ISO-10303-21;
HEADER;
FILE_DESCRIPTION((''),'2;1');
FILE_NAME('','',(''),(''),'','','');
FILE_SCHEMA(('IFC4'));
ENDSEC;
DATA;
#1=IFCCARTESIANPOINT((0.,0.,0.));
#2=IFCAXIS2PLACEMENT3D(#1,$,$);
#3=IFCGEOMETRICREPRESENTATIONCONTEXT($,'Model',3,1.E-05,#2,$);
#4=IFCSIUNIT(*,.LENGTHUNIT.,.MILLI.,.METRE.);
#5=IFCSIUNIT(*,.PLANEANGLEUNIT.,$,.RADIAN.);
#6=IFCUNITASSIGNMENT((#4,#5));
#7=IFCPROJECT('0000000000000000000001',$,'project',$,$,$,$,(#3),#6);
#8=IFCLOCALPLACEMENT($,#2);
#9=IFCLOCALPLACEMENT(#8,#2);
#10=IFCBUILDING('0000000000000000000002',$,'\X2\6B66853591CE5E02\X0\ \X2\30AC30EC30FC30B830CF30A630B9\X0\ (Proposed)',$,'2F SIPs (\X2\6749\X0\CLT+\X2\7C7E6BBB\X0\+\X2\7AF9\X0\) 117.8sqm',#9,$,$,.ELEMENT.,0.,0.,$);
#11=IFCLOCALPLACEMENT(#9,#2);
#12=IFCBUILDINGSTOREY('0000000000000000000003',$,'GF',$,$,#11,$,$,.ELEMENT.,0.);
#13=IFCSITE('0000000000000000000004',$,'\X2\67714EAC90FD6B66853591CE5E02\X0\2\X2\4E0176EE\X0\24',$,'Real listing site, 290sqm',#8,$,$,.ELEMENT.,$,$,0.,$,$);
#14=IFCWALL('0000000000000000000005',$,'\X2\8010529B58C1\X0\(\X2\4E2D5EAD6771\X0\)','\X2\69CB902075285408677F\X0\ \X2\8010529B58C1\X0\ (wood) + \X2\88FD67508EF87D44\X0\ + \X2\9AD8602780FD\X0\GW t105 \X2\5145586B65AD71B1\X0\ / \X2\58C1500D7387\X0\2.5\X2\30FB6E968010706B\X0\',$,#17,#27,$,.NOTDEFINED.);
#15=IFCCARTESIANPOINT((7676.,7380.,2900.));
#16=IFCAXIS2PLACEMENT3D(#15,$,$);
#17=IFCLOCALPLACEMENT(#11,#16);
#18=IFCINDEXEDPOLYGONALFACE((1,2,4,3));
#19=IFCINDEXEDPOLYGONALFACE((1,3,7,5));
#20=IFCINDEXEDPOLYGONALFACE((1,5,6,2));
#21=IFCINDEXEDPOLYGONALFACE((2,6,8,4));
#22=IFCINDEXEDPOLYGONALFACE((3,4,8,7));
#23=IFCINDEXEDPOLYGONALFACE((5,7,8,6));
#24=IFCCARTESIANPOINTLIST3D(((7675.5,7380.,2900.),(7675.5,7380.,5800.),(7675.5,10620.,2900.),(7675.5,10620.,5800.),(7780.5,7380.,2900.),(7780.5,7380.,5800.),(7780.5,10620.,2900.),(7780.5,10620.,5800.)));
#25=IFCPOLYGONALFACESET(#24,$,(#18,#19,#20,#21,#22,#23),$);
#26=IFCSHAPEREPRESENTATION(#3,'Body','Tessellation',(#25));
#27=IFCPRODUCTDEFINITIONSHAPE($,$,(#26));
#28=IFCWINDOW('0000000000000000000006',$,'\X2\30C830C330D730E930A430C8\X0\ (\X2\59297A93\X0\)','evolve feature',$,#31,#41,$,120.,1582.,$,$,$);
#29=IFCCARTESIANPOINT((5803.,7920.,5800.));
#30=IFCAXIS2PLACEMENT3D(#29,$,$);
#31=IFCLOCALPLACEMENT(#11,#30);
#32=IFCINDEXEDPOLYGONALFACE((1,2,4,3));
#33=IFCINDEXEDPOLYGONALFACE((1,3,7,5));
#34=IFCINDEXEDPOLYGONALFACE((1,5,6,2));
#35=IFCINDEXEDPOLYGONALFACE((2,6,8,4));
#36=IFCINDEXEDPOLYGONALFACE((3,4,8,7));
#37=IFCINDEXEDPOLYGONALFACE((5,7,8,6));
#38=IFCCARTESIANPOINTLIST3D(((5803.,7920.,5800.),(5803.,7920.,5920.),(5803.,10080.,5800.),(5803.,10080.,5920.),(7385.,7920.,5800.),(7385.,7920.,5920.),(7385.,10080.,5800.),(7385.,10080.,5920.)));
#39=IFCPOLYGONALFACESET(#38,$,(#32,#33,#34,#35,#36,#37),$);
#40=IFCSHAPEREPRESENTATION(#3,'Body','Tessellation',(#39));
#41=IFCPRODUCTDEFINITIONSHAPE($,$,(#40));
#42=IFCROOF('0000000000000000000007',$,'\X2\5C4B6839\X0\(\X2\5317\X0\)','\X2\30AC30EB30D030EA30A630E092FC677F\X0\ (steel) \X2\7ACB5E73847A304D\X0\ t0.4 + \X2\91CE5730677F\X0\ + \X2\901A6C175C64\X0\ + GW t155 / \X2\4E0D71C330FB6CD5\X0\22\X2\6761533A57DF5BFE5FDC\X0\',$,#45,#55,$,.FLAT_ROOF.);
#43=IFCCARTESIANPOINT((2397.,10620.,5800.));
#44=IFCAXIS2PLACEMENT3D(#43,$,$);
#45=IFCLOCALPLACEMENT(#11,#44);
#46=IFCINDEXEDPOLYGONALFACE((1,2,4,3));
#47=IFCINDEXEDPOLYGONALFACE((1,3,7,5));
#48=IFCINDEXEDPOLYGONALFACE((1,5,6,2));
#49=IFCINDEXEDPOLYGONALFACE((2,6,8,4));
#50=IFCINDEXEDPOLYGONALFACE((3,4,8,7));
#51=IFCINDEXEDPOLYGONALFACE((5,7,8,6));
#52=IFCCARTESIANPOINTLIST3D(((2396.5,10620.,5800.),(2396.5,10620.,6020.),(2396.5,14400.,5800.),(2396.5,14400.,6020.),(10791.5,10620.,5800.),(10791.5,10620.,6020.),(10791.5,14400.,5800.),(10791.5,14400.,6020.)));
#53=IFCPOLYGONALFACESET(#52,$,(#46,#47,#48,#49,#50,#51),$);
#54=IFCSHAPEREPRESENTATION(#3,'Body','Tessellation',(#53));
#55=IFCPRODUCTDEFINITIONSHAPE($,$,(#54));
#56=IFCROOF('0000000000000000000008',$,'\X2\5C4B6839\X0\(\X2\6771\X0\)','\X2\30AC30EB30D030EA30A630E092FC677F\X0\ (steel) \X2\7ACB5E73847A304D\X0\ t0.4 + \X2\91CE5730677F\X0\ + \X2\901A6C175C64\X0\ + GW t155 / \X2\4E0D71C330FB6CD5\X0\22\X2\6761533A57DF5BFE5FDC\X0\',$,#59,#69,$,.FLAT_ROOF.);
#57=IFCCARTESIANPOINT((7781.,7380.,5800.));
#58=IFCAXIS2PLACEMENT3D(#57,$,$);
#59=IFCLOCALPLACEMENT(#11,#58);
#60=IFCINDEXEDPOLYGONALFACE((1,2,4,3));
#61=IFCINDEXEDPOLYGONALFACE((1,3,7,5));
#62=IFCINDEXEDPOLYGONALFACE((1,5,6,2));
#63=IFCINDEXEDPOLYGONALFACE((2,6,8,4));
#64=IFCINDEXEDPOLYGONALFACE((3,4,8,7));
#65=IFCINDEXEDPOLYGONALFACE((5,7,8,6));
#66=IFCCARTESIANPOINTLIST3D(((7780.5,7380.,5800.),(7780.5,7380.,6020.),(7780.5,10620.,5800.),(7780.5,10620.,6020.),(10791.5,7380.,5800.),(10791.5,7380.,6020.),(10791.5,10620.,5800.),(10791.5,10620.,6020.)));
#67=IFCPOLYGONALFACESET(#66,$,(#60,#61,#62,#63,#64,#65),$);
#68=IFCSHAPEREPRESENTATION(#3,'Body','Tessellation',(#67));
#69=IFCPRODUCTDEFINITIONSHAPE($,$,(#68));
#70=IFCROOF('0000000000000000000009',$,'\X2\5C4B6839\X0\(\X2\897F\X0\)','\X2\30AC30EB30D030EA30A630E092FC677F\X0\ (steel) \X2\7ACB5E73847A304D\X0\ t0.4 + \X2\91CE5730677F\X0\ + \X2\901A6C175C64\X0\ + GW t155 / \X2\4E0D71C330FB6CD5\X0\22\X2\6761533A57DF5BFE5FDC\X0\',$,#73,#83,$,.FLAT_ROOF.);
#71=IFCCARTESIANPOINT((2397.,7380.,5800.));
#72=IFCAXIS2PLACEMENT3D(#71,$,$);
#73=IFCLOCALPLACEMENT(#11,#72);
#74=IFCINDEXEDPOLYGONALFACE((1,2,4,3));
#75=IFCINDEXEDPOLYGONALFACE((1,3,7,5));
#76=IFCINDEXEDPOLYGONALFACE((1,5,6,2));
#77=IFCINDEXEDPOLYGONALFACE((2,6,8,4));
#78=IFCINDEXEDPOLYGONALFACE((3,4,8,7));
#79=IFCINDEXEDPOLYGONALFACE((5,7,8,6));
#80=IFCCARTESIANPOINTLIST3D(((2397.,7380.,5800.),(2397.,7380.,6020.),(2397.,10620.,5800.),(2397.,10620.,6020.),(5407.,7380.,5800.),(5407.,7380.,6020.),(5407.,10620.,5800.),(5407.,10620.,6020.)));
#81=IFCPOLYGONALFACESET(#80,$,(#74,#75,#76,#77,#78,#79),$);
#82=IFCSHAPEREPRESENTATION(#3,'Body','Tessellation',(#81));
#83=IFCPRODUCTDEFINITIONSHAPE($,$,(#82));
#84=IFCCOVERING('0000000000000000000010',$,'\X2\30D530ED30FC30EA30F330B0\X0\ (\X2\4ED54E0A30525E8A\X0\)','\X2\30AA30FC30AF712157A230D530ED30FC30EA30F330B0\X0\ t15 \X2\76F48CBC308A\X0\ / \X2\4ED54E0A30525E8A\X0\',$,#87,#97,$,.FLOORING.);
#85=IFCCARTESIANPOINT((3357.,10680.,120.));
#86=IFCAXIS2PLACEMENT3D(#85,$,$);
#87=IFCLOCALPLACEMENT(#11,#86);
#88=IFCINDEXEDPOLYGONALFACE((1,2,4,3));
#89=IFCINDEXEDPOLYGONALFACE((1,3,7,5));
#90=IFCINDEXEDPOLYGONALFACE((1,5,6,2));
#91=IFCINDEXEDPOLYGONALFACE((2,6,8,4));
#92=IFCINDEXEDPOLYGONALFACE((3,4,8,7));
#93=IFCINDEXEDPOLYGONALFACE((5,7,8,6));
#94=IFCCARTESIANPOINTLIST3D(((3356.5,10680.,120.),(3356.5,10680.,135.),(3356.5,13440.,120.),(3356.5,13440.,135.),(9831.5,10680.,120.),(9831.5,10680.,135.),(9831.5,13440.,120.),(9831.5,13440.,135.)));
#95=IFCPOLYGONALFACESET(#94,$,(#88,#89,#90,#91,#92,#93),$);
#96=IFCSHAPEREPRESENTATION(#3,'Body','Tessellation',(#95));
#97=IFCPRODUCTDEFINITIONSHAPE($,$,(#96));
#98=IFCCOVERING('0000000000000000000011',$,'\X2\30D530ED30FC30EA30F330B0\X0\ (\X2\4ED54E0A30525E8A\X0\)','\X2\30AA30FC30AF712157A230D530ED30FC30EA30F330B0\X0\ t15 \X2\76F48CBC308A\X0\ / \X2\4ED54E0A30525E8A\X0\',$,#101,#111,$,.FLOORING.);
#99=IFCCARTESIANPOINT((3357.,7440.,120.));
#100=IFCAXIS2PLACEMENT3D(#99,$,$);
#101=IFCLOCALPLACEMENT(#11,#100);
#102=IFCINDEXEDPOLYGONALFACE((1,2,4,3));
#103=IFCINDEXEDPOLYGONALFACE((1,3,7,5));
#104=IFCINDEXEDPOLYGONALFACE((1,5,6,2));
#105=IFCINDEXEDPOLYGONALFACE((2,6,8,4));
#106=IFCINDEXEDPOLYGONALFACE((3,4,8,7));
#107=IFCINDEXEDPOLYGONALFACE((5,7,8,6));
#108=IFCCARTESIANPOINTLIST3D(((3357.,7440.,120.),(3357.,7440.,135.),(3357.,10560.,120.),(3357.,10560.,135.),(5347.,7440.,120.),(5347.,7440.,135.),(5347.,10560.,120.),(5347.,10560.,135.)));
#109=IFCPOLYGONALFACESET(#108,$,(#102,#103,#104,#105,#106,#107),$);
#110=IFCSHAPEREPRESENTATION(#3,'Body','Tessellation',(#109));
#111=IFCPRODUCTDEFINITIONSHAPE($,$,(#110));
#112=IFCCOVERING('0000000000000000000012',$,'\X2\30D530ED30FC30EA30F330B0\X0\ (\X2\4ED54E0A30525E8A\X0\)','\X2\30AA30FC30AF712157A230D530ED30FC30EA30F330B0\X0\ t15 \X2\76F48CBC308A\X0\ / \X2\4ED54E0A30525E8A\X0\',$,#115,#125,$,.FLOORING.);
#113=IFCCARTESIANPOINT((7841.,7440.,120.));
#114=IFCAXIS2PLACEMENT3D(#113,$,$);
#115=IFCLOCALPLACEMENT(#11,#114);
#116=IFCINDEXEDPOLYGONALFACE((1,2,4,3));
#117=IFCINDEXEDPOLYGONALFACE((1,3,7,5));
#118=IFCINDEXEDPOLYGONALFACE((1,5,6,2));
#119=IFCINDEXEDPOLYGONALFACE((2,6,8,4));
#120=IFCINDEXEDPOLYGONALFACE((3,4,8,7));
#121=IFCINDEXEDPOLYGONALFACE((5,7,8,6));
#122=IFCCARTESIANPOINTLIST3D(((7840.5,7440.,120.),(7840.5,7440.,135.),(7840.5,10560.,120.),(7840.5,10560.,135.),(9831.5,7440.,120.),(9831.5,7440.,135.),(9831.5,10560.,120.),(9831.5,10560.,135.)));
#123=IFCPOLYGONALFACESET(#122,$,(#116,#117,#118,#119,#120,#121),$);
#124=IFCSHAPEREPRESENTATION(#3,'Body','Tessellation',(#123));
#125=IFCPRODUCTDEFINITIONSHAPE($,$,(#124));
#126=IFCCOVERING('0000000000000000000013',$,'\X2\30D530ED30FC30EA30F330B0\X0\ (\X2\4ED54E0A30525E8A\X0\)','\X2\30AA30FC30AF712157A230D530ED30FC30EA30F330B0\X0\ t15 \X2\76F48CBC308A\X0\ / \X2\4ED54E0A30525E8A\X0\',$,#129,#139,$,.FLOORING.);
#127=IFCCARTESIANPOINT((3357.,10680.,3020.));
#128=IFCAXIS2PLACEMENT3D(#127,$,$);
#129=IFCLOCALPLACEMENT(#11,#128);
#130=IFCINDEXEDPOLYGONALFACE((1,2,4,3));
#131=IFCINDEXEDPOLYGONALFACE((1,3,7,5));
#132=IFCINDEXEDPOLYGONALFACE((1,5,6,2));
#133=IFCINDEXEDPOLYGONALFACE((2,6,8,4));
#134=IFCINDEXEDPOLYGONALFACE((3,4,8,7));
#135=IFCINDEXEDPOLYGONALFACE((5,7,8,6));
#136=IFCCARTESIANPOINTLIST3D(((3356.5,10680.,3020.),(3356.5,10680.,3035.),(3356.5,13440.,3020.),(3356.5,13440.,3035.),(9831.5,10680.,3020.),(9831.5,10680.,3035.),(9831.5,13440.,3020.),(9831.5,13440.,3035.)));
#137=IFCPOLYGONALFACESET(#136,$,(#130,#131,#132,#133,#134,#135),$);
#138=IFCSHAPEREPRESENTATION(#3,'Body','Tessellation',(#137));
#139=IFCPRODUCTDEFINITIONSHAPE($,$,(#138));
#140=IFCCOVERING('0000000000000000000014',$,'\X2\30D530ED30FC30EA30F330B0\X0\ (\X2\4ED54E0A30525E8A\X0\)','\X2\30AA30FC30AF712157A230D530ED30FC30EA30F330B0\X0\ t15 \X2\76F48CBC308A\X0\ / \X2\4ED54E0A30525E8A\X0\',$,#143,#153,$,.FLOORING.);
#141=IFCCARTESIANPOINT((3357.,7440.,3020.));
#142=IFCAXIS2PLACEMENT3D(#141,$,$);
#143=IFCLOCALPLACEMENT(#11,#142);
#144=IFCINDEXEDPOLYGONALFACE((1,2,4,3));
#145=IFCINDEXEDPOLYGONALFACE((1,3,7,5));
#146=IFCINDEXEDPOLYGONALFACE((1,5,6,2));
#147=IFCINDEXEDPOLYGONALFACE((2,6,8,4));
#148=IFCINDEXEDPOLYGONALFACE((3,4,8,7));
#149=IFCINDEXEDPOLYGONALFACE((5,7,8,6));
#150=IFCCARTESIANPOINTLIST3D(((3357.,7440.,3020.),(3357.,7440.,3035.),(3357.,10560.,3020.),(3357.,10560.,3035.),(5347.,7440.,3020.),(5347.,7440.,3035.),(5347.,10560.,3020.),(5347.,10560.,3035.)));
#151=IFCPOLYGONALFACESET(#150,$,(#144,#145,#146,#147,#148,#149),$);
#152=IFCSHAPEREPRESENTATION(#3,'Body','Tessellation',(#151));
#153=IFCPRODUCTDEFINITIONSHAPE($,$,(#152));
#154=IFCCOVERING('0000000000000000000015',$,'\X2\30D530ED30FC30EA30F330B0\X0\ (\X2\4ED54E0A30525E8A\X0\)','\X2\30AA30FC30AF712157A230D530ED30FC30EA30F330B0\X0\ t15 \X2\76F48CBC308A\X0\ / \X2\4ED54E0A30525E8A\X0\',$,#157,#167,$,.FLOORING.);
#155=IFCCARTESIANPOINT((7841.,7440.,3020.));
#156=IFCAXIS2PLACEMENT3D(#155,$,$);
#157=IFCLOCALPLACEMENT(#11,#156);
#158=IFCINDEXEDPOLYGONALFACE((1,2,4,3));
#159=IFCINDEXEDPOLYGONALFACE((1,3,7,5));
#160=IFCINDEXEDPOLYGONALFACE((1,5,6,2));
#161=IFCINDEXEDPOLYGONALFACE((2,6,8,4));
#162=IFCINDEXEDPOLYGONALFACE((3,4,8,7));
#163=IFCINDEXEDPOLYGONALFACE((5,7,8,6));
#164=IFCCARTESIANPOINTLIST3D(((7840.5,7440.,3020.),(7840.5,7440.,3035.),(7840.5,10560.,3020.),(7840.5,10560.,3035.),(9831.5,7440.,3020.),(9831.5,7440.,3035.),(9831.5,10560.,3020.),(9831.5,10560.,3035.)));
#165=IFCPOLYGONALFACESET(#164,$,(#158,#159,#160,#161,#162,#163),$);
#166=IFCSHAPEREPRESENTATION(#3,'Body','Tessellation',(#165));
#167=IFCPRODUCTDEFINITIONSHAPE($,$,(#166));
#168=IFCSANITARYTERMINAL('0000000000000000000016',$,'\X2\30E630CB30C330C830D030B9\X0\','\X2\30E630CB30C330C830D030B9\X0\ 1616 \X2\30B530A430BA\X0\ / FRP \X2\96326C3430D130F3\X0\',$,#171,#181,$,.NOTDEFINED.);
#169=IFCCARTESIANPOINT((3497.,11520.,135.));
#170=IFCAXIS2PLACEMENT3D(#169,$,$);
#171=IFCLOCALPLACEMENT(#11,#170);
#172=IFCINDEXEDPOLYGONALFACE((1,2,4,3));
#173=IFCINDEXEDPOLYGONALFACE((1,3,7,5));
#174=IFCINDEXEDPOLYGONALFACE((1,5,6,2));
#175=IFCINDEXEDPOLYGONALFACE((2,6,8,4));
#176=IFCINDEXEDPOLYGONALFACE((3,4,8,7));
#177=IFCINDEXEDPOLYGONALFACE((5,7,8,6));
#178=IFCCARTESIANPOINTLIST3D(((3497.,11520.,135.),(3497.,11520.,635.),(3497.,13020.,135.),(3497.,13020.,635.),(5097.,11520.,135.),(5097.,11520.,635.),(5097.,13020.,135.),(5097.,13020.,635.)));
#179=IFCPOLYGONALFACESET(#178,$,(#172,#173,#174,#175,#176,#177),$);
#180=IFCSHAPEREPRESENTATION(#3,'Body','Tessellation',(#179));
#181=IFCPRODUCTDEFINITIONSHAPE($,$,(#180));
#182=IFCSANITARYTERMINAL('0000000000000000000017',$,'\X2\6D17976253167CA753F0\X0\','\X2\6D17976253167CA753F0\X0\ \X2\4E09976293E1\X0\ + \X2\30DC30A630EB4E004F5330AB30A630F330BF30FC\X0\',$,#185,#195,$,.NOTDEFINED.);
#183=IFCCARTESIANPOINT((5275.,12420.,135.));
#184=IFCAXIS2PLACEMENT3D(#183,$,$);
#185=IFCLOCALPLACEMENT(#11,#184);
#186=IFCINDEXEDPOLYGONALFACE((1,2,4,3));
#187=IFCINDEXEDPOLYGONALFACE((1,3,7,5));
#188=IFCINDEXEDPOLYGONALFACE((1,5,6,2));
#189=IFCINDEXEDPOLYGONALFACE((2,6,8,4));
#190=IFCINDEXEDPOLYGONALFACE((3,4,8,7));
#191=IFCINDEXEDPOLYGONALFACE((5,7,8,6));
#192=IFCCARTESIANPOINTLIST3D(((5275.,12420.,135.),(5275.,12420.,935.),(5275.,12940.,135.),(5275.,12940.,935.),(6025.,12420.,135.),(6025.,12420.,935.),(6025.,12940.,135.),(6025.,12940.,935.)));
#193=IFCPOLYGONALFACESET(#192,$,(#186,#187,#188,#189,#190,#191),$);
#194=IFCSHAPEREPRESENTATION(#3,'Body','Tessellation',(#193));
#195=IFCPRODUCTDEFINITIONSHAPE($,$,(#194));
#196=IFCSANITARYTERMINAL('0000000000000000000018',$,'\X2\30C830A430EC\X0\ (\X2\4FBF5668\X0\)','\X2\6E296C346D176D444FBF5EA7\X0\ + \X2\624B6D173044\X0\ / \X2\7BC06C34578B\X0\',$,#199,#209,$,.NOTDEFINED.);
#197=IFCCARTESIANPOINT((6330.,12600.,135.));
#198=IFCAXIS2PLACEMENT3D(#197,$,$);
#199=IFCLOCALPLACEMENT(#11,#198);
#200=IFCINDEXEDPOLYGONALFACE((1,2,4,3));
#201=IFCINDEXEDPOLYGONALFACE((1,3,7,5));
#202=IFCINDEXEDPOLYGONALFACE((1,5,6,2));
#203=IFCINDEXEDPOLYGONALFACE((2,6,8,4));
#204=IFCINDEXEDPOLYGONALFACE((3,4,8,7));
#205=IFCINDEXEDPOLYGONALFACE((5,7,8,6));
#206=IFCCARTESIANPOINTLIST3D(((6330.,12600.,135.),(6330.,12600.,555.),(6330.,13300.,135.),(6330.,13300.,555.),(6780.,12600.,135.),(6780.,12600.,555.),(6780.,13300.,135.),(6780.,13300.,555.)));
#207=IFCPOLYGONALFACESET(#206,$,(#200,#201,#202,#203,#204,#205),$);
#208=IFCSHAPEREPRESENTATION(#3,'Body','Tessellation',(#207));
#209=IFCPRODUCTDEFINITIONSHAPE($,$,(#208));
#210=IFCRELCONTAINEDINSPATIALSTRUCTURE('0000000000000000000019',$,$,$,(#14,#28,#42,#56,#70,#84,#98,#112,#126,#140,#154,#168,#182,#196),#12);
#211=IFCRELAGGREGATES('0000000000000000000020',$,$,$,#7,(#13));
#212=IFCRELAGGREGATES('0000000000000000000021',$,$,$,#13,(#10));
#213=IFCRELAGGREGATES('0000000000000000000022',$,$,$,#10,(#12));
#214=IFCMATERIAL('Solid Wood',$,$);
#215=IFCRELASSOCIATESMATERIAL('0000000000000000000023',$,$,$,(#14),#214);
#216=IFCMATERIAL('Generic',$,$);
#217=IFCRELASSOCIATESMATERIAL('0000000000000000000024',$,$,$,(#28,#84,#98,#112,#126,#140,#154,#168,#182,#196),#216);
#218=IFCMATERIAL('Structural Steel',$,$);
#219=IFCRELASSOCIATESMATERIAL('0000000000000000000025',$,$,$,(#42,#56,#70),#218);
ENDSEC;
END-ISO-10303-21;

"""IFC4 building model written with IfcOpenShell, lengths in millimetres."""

from ifc_helpers import new_model, si_unit, frame, frame_2d, origin, place, context, project, spatial, rectangle, extrude, material, element, save


model = new_model("IFC4")

# Units and contexts
model_context = context("Model", 3, precision=1e-05, world=origin())
ifc_project = project(units=[si_unit("LENGTHUNIT", "METRE", prefix="MILLI"), si_unit("PLANEANGLEUNIT", "RADIAN")], contexts=[model_context])

# Site, building, storey
site_placement = place(None, origin())
site = spatial("IfcSite", under=ifc_project, at=site_placement, Name="東京都武蔵野市2丁目24", ObjectType="Real listing site, 290sqm", CompositionType="ELEMENT", RefElevation=0.0)
building_placement = place(site_placement, origin())
building = spatial("IfcBuilding", under=site, at=building_placement, Name="武蔵野市 ガレージハウス (Proposed)", ObjectType="2F SIPs (杉CLT+籾殻+竹) 117.8sqm", CompositionType="ELEMENT", ElevationOfRefHeight=0.0, ElevationOfTerrain=0.0)
storey_placement = place(building_placement, origin())
storey = spatial("IfcBuildingStorey", under=building, at=storey_placement, Name="GF", CompositionType="ELEMENT", Elevation=0.0)

# Shared definitions
ifc_material_1 = material(Name="Solid Wood")

# Wall
wall_1_placement = place(storey_placement, frame((7676.0, 7380.0, 2900.0)))
element("IfcWall", 1, at=wall_1_placement, inside=storey, material=ifc_material_1, Name="耐力壁(中庭東)", Description="構造用合板 耐力壁 (wood) + 製材軸組 + 高性能GW t105 充填断熱 / 壁倍率2.5・準耐火", PredefinedType="NOTDEFINED", context=model_context, shape_type="SweptSolid", body=[
    extrude(rectangle(XDim=105.0, YDim=3240.0, at=frame_2d((52.0, 1620.0))), frame((7676.0, 7380.0, 2900.0)), (0.0, 0.0, 1.0), 2900.0),
])

# Window
ifc_material_2 = material(Name="Generic")
window_1_placement = place(storey_placement, frame((5803.0, 7920.0, 5800.0)))
element("IfcWindow", 2, at=window_1_placement, inside=storey, material=ifc_material_2, Name="トップライト (天窓)", Description="evolve feature", OverallHeight=120.0, OverallWidth=1582.0, context=model_context, shape_type="SweptSolid", body=[
    extrude(rectangle(XDim=1582.0, YDim=2160.0, at=frame_2d((791.0, 1080.0))), frame((5803.0, 7920.0, 5800.0)), (0.0, 0.0, 1.0), 120.0),
])

# Roofs
ifc_material_3 = material(Name="Structural Steel")
roof_1_placement = place(storey_placement, frame((2397.0, 10620.0, 5800.0)))
element("IfcRoof", 3, at=roof_1_placement, inside=storey, material=ifc_material_3, Name="屋根(北)", Description="ガルバリウム鋼板 (steel) 立平葺き t0.4 + 野地板 + 通気層 + GW t155 / 不燃・法22条区域対応", PredefinedType="FLAT_ROOF", context=model_context, shape_type="SweptSolid", body=[
    extrude(rectangle(XDim=8395.0, YDim=3780.0, at=frame_2d((4197.0, 1890.0))), frame((2397.0, 10620.0, 5800.0)), (0.0, 0.0, 1.0), 220.0),
])
roof_2_placement = place(storey_placement, frame((7781.0, 7380.0, 5800.0)))
element("IfcRoof", 4, at=roof_2_placement, inside=storey, material=ifc_material_3, Name="屋根(東)", Description="ガルバリウム鋼板 (steel) 立平葺き t0.4 + 野地板 + 通気層 + GW t155 / 不燃・法22条区域対応", PredefinedType="FLAT_ROOF", context=model_context, shape_type="SweptSolid", body=[
    extrude(rectangle(XDim=3011.0, YDim=3240.0, at=frame_2d((1505.0, 1620.0))), frame((7781.0, 7380.0, 5800.0)), (0.0, 0.0, 1.0), 220.0),
])
roof_3_placement = place(storey_placement, frame((2397.0, 7380.0, 5800.0)))
element("IfcRoof", 5, at=roof_3_placement, inside=storey, material=ifc_material_3, Name="屋根(西)", Description="ガルバリウム鋼板 (steel) 立平葺き t0.4 + 野地板 + 通気層 + GW t155 / 不燃・法22条区域対応", PredefinedType="FLAT_ROOF", context=model_context, shape_type="SweptSolid", body=[
    extrude(rectangle(XDim=3010.0, YDim=3240.0, at=frame_2d((1505.0, 1620.0))), frame((2397.0, 7380.0, 5800.0)), (0.0, 0.0, 1.0), 220.0),
])

# Coverings
covering_1_placement = place(storey_placement, frame((3357.0, 10680.0, 120.0)))
element("IfcCovering", 6, at=covering_1_placement, inside=storey, material=ifc_material_2, Name="フローリング (仕上げ床)", Description="オーク無垢フローリング t15 直貼り / 仕上げ床", PredefinedType="FLOORING", context=model_context, shape_type="SweptSolid", body=[
    extrude(rectangle(XDim=6475.0, YDim=2760.0, at=frame_2d((3237.0, 1380.0))), frame((3357.0, 10680.0, 120.0)), (0.0, 0.0, 1.0), 15.0),
])
covering_2_placement = place(storey_placement, frame((3357.0, 7440.0, 120.0)))
element("IfcCovering", 7, at=covering_2_placement, inside=storey, material=ifc_material_2, Name="フローリング (仕上げ床)", Description="オーク無垢フローリング t15 直貼り / 仕上げ床", PredefinedType="FLOORING", context=model_context, shape_type="SweptSolid", body=[
    extrude(rectangle(XDim=1990.0, YDim=3120.0, at=frame_2d((995.0, 1560.0))), frame((3357.0, 7440.0, 120.0)), (0.0, 0.0, 1.0), 15.0),
])
covering_3_placement = place(storey_placement, frame((7841.0, 7440.0, 120.0)))
element("IfcCovering", 8, at=covering_3_placement, inside=storey, material=ifc_material_2, Name="フローリング (仕上げ床)", Description="オーク無垢フローリング t15 直貼り / 仕上げ床", PredefinedType="FLOORING", context=model_context, shape_type="SweptSolid", body=[
    extrude(rectangle(XDim=1991.0, YDim=3120.0, at=frame_2d((995.0, 1560.0))), frame((7841.0, 7440.0, 120.0)), (0.0, 0.0, 1.0), 15.0),
])
covering_4_placement = place(storey_placement, frame((3357.0, 10680.0, 3020.0)))
element("IfcCovering", 9, at=covering_4_placement, inside=storey, material=ifc_material_2, Name="フローリング (仕上げ床)", Description="オーク無垢フローリング t15 直貼り / 仕上げ床", PredefinedType="FLOORING", context=model_context, shape_type="SweptSolid", body=[
    extrude(rectangle(XDim=6475.0, YDim=2760.0, at=frame_2d((3237.0, 1380.0))), frame((3357.0, 10680.0, 3020.0)), (0.0, 0.0, 1.0), 15.0),
])
covering_5_placement = place(storey_placement, frame((3357.0, 7440.0, 3020.0)))
element("IfcCovering", 10, at=covering_5_placement, inside=storey, material=ifc_material_2, Name="フローリング (仕上げ床)", Description="オーク無垢フローリング t15 直貼り / 仕上げ床", PredefinedType="FLOORING", context=model_context, shape_type="SweptSolid", body=[
    extrude(rectangle(XDim=1990.0, YDim=3120.0, at=frame_2d((995.0, 1560.0))), frame((3357.0, 7440.0, 3020.0)), (0.0, 0.0, 1.0), 15.0),
])
covering_6_placement = place(storey_placement, frame((7841.0, 7440.0, 3020.0)))
element("IfcCovering", 11, at=covering_6_placement, inside=storey, material=ifc_material_2, Name="フローリング (仕上げ床)", Description="オーク無垢フローリング t15 直貼り / 仕上げ床", PredefinedType="FLOORING", context=model_context, shape_type="SweptSolid", body=[
    extrude(rectangle(XDim=1991.0, YDim=3120.0, at=frame_2d((995.0, 1560.0))), frame((7841.0, 7440.0, 3020.0)), (0.0, 0.0, 1.0), 15.0),
])

# Sanitary terminals
sanitary_terminal_1_placement = place(storey_placement, frame((3497.0, 11520.0, 135.0)))
element("IfcSanitaryTerminal", 12, at=sanitary_terminal_1_placement, inside=storey, material=ifc_material_2, Name="ユニットバス", Description="ユニットバス 1616 サイズ / FRP 防水パン", PredefinedType="NOTDEFINED", context=model_context, shape_type="SweptSolid", body=[
    extrude(rectangle(XDim=1600.0, YDim=1500.0, at=frame_2d((800.0, 750.0))), frame((3497.0, 11520.0, 135.0)), (0.0, 0.0, 1.0), 500.0),
])
sanitary_terminal_2_placement = place(storey_placement, frame((5275.0, 12420.0, 135.0)))
element("IfcSanitaryTerminal", 13, at=sanitary_terminal_2_placement, inside=storey, material=ifc_material_2, Name="洗面化粧台", Description="洗面化粧台 三面鏡 + ボウル一体カウンター", PredefinedType="NOTDEFINED", context=model_context, shape_type="SweptSolid", body=[
    extrude(rectangle(XDim=750.0, YDim=520.0, at=frame_2d((375.0, 260.0))), frame((5275.0, 12420.0, 135.0)), (0.0, 0.0, 1.0), 800.0),
])
sanitary_terminal_3_placement = place(storey_placement, frame((6330.0, 12600.0, 135.0)))
element("IfcSanitaryTerminal", 14, at=sanitary_terminal_3_placement, inside=storey, material=ifc_material_2, Name="トイレ (便器)", Description="温水洗浄便座 + 手洗い / 節水型", PredefinedType="NOTDEFINED", context=model_context, shape_type="SweptSolid", body=[
    extrude(rectangle(XDim=450.0, YDim=700.0, at=frame_2d((225.0, 350.0))), frame((6330.0, 12600.0, 135.0)), (0.0, 0.0, 1.0), 420.0),
])

save(model, "model.ifc")
